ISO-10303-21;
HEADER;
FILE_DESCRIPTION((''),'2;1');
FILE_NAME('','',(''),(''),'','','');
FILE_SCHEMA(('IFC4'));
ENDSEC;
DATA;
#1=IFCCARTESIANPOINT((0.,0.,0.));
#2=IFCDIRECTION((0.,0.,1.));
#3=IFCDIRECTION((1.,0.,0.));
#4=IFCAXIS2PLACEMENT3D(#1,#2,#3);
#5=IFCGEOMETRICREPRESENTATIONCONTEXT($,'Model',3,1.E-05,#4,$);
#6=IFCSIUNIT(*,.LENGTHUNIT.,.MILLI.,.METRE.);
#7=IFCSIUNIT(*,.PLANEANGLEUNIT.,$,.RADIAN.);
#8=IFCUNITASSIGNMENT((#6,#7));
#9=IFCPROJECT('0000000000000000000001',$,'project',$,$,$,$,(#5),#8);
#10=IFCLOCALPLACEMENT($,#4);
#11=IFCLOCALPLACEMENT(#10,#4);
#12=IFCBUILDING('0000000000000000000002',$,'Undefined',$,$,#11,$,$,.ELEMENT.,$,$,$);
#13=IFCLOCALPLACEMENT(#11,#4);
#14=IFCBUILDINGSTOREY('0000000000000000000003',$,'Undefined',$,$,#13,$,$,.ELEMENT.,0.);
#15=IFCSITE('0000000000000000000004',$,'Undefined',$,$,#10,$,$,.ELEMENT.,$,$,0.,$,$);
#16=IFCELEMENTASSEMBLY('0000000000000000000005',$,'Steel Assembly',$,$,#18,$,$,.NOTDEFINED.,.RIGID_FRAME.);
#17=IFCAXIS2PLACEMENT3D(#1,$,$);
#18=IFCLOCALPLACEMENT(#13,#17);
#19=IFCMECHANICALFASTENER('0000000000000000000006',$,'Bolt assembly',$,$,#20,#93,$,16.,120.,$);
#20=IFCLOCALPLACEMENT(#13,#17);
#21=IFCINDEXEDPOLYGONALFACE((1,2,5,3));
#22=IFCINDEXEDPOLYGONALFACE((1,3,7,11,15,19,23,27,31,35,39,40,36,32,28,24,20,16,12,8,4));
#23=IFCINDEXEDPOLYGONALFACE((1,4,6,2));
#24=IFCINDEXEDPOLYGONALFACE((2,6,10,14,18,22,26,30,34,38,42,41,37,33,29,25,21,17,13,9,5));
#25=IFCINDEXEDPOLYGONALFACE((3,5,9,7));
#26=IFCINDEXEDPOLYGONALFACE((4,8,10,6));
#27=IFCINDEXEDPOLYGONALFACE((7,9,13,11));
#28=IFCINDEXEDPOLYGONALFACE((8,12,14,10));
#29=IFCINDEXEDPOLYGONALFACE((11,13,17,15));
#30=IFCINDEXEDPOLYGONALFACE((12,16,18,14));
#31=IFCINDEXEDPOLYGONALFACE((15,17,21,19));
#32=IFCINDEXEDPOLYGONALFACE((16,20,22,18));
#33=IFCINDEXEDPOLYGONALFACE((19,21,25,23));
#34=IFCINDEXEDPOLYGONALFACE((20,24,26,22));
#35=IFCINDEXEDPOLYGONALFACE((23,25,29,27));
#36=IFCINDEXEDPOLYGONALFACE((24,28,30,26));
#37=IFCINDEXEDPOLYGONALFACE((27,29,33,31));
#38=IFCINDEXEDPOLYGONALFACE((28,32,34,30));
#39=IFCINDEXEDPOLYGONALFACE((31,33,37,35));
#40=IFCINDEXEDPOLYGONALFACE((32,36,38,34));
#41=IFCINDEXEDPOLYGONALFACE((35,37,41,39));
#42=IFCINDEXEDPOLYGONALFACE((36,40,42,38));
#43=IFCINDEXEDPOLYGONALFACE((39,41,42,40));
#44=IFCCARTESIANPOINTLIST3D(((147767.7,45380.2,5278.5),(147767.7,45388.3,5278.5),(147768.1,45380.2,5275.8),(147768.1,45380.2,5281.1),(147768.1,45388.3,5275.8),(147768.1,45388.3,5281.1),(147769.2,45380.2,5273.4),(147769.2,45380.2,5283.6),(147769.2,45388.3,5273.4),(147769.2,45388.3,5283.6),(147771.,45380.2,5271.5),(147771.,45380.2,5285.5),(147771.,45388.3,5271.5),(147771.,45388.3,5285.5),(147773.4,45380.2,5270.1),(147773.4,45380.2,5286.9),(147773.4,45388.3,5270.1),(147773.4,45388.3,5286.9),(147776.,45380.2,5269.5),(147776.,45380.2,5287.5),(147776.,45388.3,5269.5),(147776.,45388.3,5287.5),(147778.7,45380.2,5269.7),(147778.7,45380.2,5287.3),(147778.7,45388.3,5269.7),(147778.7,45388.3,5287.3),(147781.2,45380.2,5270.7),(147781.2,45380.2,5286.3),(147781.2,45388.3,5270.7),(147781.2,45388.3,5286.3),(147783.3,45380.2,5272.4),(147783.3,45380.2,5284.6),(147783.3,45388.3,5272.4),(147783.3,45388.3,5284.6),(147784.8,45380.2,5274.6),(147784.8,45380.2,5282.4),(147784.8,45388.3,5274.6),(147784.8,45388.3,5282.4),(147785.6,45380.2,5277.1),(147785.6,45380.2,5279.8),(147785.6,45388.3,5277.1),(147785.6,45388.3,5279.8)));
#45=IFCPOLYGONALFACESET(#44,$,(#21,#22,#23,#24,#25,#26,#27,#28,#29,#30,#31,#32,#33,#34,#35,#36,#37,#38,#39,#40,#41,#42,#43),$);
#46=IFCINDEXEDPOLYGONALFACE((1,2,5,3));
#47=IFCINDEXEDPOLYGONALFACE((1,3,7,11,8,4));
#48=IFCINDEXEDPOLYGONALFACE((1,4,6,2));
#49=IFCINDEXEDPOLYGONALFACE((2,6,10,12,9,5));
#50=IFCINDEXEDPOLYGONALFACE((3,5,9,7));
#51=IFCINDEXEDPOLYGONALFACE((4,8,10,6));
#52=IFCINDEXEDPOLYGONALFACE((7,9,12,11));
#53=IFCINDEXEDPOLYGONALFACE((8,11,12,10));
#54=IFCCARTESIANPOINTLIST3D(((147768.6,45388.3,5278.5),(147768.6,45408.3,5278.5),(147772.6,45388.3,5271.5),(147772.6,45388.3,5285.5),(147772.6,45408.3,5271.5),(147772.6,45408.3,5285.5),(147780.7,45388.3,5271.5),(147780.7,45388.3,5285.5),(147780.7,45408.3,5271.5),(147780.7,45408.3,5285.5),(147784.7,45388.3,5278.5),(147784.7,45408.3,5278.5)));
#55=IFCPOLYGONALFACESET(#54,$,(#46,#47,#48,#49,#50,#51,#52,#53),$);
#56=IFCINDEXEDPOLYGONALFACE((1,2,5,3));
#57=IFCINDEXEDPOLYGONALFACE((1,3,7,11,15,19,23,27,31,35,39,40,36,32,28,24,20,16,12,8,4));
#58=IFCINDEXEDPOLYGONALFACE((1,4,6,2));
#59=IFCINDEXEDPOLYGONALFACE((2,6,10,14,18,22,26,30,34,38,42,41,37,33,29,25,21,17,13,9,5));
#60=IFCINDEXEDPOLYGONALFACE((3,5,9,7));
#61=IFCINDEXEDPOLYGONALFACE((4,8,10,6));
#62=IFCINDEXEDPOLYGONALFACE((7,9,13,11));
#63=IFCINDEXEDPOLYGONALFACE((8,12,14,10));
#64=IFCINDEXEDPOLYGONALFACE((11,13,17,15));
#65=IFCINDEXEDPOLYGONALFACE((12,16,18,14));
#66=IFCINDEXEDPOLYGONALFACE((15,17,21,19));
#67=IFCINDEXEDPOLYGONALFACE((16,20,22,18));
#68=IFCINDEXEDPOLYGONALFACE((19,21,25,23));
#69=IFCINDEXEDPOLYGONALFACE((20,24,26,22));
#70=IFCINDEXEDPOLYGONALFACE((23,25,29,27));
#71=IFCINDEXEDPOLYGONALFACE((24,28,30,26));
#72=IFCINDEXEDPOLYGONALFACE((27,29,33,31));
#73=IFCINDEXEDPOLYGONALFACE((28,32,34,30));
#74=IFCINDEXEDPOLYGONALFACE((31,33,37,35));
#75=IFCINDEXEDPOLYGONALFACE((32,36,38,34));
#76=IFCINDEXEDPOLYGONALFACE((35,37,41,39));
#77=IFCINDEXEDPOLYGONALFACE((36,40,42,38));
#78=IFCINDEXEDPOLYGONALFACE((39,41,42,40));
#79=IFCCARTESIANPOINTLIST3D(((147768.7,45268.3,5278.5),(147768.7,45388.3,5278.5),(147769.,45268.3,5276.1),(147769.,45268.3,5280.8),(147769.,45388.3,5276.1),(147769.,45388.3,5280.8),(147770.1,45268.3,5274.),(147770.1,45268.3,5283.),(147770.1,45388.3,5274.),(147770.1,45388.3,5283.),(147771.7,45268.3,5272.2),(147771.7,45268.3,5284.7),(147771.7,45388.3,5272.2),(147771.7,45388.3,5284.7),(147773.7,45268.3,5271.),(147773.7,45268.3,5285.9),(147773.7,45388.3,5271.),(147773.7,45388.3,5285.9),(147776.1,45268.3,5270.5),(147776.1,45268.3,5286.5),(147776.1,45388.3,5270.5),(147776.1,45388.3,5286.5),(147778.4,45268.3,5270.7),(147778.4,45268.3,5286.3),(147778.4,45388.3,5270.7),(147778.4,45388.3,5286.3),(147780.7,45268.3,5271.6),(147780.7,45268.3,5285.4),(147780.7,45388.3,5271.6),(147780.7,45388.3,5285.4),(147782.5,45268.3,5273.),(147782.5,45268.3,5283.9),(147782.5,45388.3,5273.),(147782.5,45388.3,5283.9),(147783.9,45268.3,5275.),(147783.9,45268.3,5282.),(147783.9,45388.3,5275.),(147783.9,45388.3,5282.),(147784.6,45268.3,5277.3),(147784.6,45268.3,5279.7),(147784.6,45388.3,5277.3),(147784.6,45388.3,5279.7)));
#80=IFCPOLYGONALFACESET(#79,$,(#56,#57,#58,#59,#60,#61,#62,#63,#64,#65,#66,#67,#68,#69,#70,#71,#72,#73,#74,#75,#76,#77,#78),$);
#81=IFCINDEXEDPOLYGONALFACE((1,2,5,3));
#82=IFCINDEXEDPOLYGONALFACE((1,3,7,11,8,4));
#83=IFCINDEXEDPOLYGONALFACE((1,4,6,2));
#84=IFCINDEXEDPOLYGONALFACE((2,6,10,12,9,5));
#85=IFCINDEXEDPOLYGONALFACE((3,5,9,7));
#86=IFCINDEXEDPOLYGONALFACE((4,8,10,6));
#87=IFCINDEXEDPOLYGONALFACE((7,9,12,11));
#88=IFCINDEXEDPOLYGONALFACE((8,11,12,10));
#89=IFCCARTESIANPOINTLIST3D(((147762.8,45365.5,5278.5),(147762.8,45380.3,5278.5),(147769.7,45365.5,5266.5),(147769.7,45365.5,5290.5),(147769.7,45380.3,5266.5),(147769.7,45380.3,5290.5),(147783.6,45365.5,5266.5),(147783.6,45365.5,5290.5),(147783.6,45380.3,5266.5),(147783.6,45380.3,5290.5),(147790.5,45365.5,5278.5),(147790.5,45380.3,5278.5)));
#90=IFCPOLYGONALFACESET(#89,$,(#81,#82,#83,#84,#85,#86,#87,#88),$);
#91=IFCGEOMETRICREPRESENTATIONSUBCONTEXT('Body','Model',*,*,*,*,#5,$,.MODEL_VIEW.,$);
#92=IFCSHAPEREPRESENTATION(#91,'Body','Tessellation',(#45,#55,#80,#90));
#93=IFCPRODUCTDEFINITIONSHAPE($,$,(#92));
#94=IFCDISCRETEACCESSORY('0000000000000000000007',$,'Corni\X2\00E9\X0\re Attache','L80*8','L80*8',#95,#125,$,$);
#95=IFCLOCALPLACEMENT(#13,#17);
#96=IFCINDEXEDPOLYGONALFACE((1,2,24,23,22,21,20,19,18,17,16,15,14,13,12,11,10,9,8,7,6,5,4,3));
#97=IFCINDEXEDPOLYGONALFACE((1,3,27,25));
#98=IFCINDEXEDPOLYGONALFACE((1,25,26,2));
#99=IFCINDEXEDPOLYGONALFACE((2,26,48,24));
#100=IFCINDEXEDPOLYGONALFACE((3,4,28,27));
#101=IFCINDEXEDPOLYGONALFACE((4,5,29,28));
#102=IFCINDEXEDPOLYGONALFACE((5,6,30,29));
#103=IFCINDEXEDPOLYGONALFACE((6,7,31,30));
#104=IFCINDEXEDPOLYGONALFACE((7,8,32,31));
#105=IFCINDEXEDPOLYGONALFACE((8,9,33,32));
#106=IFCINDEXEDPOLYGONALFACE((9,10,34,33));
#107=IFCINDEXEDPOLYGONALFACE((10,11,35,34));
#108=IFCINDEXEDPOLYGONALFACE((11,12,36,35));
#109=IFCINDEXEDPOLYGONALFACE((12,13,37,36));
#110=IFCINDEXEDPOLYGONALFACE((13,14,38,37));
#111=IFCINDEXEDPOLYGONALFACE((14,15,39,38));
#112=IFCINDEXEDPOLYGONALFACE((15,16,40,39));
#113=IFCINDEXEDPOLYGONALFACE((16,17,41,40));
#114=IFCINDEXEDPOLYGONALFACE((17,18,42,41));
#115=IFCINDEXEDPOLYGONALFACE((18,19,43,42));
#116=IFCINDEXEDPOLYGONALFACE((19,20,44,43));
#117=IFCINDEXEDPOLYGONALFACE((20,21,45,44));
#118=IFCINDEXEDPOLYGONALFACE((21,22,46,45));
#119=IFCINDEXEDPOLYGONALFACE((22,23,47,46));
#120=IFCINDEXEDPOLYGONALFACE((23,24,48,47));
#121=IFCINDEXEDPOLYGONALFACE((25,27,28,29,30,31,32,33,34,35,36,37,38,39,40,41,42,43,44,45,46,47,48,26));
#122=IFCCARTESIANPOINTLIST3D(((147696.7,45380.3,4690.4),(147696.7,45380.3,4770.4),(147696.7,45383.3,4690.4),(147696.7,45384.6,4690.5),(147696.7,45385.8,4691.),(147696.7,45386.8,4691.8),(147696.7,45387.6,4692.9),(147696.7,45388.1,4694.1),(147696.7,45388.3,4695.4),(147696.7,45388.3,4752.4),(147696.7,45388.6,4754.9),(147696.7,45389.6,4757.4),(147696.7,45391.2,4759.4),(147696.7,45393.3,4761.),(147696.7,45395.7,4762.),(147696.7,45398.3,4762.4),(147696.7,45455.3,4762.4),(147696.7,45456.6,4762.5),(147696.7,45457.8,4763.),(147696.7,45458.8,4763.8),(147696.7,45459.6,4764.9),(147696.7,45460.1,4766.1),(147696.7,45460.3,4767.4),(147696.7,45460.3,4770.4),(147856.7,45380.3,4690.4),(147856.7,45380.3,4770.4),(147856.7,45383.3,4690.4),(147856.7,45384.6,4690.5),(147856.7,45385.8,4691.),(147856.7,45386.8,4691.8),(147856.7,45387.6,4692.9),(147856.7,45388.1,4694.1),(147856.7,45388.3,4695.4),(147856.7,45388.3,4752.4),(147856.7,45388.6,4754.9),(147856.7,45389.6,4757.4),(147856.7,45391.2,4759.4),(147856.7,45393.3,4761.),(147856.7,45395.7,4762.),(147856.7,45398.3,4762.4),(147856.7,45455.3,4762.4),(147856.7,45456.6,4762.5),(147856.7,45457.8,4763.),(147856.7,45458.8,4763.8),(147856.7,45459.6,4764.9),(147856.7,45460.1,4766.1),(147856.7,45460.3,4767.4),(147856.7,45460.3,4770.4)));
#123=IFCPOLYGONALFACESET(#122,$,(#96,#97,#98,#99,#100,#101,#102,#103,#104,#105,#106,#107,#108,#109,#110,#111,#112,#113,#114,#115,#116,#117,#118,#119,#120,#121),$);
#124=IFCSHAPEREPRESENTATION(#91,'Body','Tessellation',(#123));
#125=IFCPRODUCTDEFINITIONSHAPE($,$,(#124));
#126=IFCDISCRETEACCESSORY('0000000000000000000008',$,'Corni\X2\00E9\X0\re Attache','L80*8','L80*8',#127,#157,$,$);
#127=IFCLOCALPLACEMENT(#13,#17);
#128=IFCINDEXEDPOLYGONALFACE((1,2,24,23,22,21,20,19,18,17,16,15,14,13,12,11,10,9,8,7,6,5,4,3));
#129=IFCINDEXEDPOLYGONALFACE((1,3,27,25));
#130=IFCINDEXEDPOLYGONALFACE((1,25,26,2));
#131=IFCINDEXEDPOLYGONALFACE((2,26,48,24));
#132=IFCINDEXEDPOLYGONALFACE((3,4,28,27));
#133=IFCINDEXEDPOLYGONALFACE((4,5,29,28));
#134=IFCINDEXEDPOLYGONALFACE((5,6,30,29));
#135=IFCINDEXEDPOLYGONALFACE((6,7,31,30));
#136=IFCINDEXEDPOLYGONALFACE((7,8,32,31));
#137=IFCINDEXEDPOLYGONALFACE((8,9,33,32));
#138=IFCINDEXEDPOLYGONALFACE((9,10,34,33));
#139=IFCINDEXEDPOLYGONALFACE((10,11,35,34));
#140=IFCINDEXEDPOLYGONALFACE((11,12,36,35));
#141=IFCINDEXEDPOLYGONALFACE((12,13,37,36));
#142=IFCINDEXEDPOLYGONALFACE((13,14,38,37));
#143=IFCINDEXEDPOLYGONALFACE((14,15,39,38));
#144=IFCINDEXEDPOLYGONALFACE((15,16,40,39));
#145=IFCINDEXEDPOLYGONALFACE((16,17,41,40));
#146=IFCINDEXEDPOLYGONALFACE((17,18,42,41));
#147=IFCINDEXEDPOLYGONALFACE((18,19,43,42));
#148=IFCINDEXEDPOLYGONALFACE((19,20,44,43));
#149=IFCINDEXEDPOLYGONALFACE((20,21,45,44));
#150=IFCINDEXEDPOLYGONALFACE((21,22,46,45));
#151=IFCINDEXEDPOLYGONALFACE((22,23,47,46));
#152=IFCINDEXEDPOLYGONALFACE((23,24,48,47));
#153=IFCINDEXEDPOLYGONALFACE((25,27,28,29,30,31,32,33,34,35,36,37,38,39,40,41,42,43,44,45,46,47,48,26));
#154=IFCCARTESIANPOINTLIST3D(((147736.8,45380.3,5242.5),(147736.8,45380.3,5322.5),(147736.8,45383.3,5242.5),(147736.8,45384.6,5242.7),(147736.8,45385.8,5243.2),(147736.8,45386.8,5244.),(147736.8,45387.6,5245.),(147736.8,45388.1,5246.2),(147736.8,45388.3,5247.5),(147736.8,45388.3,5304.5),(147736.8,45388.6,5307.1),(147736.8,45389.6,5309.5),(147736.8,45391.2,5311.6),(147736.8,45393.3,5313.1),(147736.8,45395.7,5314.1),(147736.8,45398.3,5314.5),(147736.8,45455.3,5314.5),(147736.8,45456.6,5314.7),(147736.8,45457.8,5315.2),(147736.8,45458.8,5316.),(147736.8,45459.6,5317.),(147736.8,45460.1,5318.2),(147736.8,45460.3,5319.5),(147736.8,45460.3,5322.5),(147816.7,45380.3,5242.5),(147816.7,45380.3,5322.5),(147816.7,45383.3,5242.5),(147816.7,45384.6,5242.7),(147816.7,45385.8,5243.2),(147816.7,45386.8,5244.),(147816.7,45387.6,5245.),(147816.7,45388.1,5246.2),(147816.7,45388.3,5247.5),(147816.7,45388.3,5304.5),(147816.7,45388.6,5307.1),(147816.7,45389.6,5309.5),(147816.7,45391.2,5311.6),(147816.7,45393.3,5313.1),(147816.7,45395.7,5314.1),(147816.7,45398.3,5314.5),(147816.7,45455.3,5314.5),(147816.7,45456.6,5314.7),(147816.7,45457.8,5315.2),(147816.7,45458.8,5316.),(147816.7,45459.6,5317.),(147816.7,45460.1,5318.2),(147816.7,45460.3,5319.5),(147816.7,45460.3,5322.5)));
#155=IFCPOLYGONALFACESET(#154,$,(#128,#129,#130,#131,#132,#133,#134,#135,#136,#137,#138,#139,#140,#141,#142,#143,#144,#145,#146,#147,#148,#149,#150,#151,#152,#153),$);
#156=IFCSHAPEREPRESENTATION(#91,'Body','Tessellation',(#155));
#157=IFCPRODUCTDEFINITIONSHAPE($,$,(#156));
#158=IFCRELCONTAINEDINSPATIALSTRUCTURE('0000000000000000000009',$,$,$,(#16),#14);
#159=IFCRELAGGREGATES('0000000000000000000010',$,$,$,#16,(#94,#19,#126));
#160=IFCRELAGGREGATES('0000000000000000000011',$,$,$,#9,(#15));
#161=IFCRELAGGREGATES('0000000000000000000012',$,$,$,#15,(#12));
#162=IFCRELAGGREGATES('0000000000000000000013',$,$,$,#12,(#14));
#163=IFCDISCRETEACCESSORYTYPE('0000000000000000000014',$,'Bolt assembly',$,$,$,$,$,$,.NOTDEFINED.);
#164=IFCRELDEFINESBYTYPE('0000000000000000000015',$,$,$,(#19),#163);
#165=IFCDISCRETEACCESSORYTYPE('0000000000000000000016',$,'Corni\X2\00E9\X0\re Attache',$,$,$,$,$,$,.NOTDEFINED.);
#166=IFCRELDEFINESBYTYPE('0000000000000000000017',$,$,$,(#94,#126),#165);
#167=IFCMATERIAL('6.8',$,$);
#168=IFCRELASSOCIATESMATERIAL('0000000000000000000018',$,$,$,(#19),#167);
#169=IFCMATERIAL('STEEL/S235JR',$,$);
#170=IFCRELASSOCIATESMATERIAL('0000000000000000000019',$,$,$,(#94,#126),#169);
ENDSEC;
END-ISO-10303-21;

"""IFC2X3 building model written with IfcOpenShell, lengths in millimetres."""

from ifc_helpers import new_model, si_unit, frame, origin_with_axes, origin_2d_with_axis, place, context, subcontext, project, spatial, polyline, circle, l_section, outline, extrude, source, transform, mapped, material, type_object, element, aggregate, save


model = new_model("IFC2X3")

# Units and contexts
model_context = context("Model", 3, precision=1e-05, world=origin_with_axes())
body_context = subcontext(model_context, "Body", "Model", "MODEL_VIEW")
ifc_project = project(units=[si_unit("LENGTHUNIT", "METRE", prefix="MILLI"), si_unit("PLANEANGLEUNIT", "RADIAN")], contexts=[model_context])

# Site, building, storey
site_placement = place(None, origin_with_axes())
site = spatial("IfcSite", under=ifc_project, at=site_placement, Name="Undefined", CompositionType="ELEMENT", RefElevation=0.0)
building_placement = place(site_placement, origin_with_axes())
building = spatial("IfcBuilding", under=site, at=building_placement, Name="Undefined", CompositionType="ELEMENT")
storey_placement = place(building_placement, origin_with_axes())
storey = spatial("IfcBuildingStorey", under=building, at=storey_placement, Name="Undefined", CompositionType="ELEMENT", Elevation=0.0)

# Element assembly
ifc_material_1 = material(Name="STEEL/S235JR")
assembly_1_placement = place(storey_placement, origin_with_axes())
assembly_1 = element("IfcElementAssembly", 1, at=assembly_1_placement, inside=storey, Name="Steel Assembly", AssemblyPlace="NOTDEFINED", PredefinedType="RIGID_FRAME")

# Shared definitions
discrete_accessory_type_1 = type_object("IfcDiscreteAccessoryType", Name="Bolt assembly")

# Mechanical fastener
ifc_material_2 = material(Name="6.8")
shared_shape_1 = source(origin_with_axes(), body_context, "Body", "SweptSolid", [
    extrude(circle(Radius=9.0, at=origin_2d_with_axis()), frame((0.0, -8.0, 0.0), z_axis=(0.0, 1.0, 0.0), x_axis=(1.0, 0.0, 0.0)), (0.0, 0.0, 1.0), 8.1),
    extrude(outline(polyline([(8.1, 0.0), (4.0, 7.0), (-4.0, 7.0), (-8.1, 0.0), (-4.0, -7.0), (4.0, -7.0), (8.1, 0.0)])), frame((0.0, -28.0, 0.0), z_axis=(0.0, 1.0, 0.0), x_axis=(1.0, 0.0, 0.0)), (0.0, 0.0, 1.0), 20.0),
    extrude(circle(Radius=8.0, at=origin_2d_with_axis()), frame((0.0, -8.0, 0.0), z_axis=(0.0, 1.0, 0.0), x_axis=(1.0, 0.0, 0.0)), (0.0, 0.0, 1.0), 120.0),
    extrude(outline(polyline([(13.9, 0.0), (6.9, 12.0), (-6.9, 12.0), (-13.9, 0.0), (-6.9, -12.0), (6.9, -12.0), (13.9, 0.0)])), frame((0.0, 0.0, 0.0), z_axis=(0.0, 1.0, 0.0), x_axis=(1.0, 0.0, 0.0)), (0.0, 0.0, 1.0), 14.8),
])
mechanical_fastener_1_placement = place(assembly_1_placement, frame((147776.7, 45380.3, 5278.5), z_axis=(0.0, 0.0, 1.0), x_axis=(-1.0, 0.0, 0.0)))
mechanical_fastener_1 = element("IfcMechanicalFastener", 2, at=mechanical_fastener_1_placement, type_object=discrete_accessory_type_1, material=ifc_material_2, Name="Bolt assembly", NominalDiameter=16.0, NominalLength=120.0, context=body_context, shape_type="MappedRepresentation", body=[
    mapped(shared_shape_1, transform((0.0, 0.0, 0.0))),
])

# Discrete accessories
discrete_accessory_type_2 = type_object("IfcDiscreteAccessoryType", Name="Corniére Attache")
discrete_accessory_1_placement = place(assembly_1_placement, frame((147856.7, 45420.3, 4730.4), z_axis=(0.0, 1.0, 0.0), x_axis=(-1.0, 0.0, 0.00001)))
discrete_accessory_1 = element("IfcDiscreteAccessory", 3, at=discrete_accessory_1_placement, type_object=discrete_accessory_type_2, material=ifc_material_1, Name="Corniére Attache", Description="L80*8", ObjectType="L80*8", context=body_context, shape_type="SweptSolid", body=[
    extrude(l_section(Depth=80.0, Width=80.0, Thickness=8.0, FilletRadius=10.0, EdgeRadius=5.0, at=origin_2d_with_axis()), frame((160.0, 0.0, 0.0), z_axis=(-1.0, 0.0, 0.0), x_axis=(0.0, -1.0, 0.0)), (0.0, 0.0, 1.0), 160.0),
])
discrete_accessory_2_placement = place(assembly_1_placement, frame((147816.7, 45420.3, 5282.5), z_axis=(0.0, 1.0, 0.0), x_axis=(-1.0, 0.0, 0.0)))
discrete_accessory_2 = element("IfcDiscreteAccessory", 4, at=discrete_accessory_2_placement, type_object=discrete_accessory_type_2, material=ifc_material_1, Name="Corniére Attache", Description="L80*8", ObjectType="L80*8", context=body_context, shape_type="SweptSolid", body=[
    extrude(l_section(Depth=80.0, Width=80.0, Thickness=8.0, FilletRadius=10.0, EdgeRadius=5.0, at=origin_2d_with_axis()), frame((79.9, 0.0, 0.0), z_axis=(-1.0, 0.0, 0.0), x_axis=(0.0, -1.0, 0.0)), (0.0, 0.0, 1.0), 79.9),
])
aggregate(assembly_1, [discrete_accessory_1, mechanical_fastener_1, discrete_accessory_2])

save(model, "model.ifc")
